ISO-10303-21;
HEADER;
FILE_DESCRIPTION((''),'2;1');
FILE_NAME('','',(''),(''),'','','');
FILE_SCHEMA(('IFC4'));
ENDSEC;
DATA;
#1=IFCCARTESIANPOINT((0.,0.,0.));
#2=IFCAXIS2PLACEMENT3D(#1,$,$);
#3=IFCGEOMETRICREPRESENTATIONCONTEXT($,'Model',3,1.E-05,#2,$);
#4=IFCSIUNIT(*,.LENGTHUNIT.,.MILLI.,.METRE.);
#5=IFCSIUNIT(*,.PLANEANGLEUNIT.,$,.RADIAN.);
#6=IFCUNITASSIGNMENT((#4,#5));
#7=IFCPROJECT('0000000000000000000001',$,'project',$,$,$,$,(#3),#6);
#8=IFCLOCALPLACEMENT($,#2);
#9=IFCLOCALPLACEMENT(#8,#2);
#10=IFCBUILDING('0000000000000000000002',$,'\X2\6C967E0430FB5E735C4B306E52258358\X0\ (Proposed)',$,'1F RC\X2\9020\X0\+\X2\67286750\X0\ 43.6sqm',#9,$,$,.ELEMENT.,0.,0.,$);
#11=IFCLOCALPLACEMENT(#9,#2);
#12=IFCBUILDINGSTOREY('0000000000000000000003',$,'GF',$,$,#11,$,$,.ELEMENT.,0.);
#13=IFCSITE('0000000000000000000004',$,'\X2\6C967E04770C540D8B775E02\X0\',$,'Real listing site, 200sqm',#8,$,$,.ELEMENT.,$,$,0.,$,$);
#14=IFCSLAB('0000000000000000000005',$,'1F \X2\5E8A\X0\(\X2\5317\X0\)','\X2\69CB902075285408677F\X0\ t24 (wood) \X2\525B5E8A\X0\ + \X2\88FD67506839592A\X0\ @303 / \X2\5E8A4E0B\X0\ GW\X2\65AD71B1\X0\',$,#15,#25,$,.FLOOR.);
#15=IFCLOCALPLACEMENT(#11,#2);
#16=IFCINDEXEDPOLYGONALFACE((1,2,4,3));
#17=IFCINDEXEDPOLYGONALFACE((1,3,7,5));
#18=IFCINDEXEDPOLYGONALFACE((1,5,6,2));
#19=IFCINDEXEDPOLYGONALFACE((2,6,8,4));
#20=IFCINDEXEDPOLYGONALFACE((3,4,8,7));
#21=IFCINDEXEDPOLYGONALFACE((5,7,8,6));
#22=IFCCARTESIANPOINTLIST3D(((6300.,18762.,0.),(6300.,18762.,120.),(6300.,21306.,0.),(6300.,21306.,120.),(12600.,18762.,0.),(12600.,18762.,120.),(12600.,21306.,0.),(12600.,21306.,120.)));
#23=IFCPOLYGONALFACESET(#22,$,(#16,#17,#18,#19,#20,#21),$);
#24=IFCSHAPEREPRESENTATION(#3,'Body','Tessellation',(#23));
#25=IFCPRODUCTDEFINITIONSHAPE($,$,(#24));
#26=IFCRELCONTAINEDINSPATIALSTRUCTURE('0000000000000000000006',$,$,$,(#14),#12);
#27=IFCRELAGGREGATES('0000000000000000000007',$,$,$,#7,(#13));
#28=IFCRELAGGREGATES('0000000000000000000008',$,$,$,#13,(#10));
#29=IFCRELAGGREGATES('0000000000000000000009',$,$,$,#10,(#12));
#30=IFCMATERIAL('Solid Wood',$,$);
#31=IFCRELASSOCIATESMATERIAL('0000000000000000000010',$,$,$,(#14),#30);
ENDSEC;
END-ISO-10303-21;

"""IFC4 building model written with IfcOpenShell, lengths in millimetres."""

from ifc_helpers import new_model, si_unit, frame, frame_2d, origin, place, context, project, spatial, rectangle, extrude, material, element, save


model = new_model("IFC4")

# Units and contexts
model_context = context("Model", 3, precision=1e-05, world=origin())
ifc_project = project(units=[si_unit("LENGTHUNIT", "METRE", prefix="MILLI"), si_unit("PLANEANGLEUNIT", "RADIAN")], contexts=[model_context])

# Site, building, storey
site_placement = place(None, origin())
site = spatial("IfcSite", under=ifc_project, at=site_placement, Name="沖縄県名護市", ObjectType="Real listing site, 200sqm", CompositionType="ELEMENT", RefElevation=0.0)
building_placement = place(site_placement, origin())
building = spatial("IfcBuilding", under=site, at=building_placement, Name="沖縄・平屋の別荘 (Proposed)", ObjectType="1F RC造+木材 43.6sqm", CompositionType="ELEMENT", ElevationOfRefHeight=0.0, ElevationOfTerrain=0.0)
storey_placement = place(building_placement, origin())
storey = spatial("IfcBuildingStorey", under=building, at=storey_placement, Name="GF", CompositionType="ELEMENT", Elevation=0.0)

# Shared definitions
ifc_material_1 = material(Name="Solid Wood")

# Slab
slab_1_placement = place(storey_placement, frame((3150.0, 9381.0, 0.0)))
element("IfcSlab", 1, at=slab_1_placement, inside=storey, material=ifc_material_1, Name="1F 床(北)", Description="構造用合板 t24 (wood) 剛床 + 製材根太 @303 / 床下 GW断熱", PredefinedType="FLOOR", context=model_context, shape_type="SweptSolid", body=[
    extrude(rectangle(XDim=6300.0, YDim=2544.0, at=frame_2d((3150.0, 1272.0))), frame((3150.0, 9381.0, 0.0)), (0.0, 0.0, 1.0), 120.0),
])

save(model, "model.ifc")
